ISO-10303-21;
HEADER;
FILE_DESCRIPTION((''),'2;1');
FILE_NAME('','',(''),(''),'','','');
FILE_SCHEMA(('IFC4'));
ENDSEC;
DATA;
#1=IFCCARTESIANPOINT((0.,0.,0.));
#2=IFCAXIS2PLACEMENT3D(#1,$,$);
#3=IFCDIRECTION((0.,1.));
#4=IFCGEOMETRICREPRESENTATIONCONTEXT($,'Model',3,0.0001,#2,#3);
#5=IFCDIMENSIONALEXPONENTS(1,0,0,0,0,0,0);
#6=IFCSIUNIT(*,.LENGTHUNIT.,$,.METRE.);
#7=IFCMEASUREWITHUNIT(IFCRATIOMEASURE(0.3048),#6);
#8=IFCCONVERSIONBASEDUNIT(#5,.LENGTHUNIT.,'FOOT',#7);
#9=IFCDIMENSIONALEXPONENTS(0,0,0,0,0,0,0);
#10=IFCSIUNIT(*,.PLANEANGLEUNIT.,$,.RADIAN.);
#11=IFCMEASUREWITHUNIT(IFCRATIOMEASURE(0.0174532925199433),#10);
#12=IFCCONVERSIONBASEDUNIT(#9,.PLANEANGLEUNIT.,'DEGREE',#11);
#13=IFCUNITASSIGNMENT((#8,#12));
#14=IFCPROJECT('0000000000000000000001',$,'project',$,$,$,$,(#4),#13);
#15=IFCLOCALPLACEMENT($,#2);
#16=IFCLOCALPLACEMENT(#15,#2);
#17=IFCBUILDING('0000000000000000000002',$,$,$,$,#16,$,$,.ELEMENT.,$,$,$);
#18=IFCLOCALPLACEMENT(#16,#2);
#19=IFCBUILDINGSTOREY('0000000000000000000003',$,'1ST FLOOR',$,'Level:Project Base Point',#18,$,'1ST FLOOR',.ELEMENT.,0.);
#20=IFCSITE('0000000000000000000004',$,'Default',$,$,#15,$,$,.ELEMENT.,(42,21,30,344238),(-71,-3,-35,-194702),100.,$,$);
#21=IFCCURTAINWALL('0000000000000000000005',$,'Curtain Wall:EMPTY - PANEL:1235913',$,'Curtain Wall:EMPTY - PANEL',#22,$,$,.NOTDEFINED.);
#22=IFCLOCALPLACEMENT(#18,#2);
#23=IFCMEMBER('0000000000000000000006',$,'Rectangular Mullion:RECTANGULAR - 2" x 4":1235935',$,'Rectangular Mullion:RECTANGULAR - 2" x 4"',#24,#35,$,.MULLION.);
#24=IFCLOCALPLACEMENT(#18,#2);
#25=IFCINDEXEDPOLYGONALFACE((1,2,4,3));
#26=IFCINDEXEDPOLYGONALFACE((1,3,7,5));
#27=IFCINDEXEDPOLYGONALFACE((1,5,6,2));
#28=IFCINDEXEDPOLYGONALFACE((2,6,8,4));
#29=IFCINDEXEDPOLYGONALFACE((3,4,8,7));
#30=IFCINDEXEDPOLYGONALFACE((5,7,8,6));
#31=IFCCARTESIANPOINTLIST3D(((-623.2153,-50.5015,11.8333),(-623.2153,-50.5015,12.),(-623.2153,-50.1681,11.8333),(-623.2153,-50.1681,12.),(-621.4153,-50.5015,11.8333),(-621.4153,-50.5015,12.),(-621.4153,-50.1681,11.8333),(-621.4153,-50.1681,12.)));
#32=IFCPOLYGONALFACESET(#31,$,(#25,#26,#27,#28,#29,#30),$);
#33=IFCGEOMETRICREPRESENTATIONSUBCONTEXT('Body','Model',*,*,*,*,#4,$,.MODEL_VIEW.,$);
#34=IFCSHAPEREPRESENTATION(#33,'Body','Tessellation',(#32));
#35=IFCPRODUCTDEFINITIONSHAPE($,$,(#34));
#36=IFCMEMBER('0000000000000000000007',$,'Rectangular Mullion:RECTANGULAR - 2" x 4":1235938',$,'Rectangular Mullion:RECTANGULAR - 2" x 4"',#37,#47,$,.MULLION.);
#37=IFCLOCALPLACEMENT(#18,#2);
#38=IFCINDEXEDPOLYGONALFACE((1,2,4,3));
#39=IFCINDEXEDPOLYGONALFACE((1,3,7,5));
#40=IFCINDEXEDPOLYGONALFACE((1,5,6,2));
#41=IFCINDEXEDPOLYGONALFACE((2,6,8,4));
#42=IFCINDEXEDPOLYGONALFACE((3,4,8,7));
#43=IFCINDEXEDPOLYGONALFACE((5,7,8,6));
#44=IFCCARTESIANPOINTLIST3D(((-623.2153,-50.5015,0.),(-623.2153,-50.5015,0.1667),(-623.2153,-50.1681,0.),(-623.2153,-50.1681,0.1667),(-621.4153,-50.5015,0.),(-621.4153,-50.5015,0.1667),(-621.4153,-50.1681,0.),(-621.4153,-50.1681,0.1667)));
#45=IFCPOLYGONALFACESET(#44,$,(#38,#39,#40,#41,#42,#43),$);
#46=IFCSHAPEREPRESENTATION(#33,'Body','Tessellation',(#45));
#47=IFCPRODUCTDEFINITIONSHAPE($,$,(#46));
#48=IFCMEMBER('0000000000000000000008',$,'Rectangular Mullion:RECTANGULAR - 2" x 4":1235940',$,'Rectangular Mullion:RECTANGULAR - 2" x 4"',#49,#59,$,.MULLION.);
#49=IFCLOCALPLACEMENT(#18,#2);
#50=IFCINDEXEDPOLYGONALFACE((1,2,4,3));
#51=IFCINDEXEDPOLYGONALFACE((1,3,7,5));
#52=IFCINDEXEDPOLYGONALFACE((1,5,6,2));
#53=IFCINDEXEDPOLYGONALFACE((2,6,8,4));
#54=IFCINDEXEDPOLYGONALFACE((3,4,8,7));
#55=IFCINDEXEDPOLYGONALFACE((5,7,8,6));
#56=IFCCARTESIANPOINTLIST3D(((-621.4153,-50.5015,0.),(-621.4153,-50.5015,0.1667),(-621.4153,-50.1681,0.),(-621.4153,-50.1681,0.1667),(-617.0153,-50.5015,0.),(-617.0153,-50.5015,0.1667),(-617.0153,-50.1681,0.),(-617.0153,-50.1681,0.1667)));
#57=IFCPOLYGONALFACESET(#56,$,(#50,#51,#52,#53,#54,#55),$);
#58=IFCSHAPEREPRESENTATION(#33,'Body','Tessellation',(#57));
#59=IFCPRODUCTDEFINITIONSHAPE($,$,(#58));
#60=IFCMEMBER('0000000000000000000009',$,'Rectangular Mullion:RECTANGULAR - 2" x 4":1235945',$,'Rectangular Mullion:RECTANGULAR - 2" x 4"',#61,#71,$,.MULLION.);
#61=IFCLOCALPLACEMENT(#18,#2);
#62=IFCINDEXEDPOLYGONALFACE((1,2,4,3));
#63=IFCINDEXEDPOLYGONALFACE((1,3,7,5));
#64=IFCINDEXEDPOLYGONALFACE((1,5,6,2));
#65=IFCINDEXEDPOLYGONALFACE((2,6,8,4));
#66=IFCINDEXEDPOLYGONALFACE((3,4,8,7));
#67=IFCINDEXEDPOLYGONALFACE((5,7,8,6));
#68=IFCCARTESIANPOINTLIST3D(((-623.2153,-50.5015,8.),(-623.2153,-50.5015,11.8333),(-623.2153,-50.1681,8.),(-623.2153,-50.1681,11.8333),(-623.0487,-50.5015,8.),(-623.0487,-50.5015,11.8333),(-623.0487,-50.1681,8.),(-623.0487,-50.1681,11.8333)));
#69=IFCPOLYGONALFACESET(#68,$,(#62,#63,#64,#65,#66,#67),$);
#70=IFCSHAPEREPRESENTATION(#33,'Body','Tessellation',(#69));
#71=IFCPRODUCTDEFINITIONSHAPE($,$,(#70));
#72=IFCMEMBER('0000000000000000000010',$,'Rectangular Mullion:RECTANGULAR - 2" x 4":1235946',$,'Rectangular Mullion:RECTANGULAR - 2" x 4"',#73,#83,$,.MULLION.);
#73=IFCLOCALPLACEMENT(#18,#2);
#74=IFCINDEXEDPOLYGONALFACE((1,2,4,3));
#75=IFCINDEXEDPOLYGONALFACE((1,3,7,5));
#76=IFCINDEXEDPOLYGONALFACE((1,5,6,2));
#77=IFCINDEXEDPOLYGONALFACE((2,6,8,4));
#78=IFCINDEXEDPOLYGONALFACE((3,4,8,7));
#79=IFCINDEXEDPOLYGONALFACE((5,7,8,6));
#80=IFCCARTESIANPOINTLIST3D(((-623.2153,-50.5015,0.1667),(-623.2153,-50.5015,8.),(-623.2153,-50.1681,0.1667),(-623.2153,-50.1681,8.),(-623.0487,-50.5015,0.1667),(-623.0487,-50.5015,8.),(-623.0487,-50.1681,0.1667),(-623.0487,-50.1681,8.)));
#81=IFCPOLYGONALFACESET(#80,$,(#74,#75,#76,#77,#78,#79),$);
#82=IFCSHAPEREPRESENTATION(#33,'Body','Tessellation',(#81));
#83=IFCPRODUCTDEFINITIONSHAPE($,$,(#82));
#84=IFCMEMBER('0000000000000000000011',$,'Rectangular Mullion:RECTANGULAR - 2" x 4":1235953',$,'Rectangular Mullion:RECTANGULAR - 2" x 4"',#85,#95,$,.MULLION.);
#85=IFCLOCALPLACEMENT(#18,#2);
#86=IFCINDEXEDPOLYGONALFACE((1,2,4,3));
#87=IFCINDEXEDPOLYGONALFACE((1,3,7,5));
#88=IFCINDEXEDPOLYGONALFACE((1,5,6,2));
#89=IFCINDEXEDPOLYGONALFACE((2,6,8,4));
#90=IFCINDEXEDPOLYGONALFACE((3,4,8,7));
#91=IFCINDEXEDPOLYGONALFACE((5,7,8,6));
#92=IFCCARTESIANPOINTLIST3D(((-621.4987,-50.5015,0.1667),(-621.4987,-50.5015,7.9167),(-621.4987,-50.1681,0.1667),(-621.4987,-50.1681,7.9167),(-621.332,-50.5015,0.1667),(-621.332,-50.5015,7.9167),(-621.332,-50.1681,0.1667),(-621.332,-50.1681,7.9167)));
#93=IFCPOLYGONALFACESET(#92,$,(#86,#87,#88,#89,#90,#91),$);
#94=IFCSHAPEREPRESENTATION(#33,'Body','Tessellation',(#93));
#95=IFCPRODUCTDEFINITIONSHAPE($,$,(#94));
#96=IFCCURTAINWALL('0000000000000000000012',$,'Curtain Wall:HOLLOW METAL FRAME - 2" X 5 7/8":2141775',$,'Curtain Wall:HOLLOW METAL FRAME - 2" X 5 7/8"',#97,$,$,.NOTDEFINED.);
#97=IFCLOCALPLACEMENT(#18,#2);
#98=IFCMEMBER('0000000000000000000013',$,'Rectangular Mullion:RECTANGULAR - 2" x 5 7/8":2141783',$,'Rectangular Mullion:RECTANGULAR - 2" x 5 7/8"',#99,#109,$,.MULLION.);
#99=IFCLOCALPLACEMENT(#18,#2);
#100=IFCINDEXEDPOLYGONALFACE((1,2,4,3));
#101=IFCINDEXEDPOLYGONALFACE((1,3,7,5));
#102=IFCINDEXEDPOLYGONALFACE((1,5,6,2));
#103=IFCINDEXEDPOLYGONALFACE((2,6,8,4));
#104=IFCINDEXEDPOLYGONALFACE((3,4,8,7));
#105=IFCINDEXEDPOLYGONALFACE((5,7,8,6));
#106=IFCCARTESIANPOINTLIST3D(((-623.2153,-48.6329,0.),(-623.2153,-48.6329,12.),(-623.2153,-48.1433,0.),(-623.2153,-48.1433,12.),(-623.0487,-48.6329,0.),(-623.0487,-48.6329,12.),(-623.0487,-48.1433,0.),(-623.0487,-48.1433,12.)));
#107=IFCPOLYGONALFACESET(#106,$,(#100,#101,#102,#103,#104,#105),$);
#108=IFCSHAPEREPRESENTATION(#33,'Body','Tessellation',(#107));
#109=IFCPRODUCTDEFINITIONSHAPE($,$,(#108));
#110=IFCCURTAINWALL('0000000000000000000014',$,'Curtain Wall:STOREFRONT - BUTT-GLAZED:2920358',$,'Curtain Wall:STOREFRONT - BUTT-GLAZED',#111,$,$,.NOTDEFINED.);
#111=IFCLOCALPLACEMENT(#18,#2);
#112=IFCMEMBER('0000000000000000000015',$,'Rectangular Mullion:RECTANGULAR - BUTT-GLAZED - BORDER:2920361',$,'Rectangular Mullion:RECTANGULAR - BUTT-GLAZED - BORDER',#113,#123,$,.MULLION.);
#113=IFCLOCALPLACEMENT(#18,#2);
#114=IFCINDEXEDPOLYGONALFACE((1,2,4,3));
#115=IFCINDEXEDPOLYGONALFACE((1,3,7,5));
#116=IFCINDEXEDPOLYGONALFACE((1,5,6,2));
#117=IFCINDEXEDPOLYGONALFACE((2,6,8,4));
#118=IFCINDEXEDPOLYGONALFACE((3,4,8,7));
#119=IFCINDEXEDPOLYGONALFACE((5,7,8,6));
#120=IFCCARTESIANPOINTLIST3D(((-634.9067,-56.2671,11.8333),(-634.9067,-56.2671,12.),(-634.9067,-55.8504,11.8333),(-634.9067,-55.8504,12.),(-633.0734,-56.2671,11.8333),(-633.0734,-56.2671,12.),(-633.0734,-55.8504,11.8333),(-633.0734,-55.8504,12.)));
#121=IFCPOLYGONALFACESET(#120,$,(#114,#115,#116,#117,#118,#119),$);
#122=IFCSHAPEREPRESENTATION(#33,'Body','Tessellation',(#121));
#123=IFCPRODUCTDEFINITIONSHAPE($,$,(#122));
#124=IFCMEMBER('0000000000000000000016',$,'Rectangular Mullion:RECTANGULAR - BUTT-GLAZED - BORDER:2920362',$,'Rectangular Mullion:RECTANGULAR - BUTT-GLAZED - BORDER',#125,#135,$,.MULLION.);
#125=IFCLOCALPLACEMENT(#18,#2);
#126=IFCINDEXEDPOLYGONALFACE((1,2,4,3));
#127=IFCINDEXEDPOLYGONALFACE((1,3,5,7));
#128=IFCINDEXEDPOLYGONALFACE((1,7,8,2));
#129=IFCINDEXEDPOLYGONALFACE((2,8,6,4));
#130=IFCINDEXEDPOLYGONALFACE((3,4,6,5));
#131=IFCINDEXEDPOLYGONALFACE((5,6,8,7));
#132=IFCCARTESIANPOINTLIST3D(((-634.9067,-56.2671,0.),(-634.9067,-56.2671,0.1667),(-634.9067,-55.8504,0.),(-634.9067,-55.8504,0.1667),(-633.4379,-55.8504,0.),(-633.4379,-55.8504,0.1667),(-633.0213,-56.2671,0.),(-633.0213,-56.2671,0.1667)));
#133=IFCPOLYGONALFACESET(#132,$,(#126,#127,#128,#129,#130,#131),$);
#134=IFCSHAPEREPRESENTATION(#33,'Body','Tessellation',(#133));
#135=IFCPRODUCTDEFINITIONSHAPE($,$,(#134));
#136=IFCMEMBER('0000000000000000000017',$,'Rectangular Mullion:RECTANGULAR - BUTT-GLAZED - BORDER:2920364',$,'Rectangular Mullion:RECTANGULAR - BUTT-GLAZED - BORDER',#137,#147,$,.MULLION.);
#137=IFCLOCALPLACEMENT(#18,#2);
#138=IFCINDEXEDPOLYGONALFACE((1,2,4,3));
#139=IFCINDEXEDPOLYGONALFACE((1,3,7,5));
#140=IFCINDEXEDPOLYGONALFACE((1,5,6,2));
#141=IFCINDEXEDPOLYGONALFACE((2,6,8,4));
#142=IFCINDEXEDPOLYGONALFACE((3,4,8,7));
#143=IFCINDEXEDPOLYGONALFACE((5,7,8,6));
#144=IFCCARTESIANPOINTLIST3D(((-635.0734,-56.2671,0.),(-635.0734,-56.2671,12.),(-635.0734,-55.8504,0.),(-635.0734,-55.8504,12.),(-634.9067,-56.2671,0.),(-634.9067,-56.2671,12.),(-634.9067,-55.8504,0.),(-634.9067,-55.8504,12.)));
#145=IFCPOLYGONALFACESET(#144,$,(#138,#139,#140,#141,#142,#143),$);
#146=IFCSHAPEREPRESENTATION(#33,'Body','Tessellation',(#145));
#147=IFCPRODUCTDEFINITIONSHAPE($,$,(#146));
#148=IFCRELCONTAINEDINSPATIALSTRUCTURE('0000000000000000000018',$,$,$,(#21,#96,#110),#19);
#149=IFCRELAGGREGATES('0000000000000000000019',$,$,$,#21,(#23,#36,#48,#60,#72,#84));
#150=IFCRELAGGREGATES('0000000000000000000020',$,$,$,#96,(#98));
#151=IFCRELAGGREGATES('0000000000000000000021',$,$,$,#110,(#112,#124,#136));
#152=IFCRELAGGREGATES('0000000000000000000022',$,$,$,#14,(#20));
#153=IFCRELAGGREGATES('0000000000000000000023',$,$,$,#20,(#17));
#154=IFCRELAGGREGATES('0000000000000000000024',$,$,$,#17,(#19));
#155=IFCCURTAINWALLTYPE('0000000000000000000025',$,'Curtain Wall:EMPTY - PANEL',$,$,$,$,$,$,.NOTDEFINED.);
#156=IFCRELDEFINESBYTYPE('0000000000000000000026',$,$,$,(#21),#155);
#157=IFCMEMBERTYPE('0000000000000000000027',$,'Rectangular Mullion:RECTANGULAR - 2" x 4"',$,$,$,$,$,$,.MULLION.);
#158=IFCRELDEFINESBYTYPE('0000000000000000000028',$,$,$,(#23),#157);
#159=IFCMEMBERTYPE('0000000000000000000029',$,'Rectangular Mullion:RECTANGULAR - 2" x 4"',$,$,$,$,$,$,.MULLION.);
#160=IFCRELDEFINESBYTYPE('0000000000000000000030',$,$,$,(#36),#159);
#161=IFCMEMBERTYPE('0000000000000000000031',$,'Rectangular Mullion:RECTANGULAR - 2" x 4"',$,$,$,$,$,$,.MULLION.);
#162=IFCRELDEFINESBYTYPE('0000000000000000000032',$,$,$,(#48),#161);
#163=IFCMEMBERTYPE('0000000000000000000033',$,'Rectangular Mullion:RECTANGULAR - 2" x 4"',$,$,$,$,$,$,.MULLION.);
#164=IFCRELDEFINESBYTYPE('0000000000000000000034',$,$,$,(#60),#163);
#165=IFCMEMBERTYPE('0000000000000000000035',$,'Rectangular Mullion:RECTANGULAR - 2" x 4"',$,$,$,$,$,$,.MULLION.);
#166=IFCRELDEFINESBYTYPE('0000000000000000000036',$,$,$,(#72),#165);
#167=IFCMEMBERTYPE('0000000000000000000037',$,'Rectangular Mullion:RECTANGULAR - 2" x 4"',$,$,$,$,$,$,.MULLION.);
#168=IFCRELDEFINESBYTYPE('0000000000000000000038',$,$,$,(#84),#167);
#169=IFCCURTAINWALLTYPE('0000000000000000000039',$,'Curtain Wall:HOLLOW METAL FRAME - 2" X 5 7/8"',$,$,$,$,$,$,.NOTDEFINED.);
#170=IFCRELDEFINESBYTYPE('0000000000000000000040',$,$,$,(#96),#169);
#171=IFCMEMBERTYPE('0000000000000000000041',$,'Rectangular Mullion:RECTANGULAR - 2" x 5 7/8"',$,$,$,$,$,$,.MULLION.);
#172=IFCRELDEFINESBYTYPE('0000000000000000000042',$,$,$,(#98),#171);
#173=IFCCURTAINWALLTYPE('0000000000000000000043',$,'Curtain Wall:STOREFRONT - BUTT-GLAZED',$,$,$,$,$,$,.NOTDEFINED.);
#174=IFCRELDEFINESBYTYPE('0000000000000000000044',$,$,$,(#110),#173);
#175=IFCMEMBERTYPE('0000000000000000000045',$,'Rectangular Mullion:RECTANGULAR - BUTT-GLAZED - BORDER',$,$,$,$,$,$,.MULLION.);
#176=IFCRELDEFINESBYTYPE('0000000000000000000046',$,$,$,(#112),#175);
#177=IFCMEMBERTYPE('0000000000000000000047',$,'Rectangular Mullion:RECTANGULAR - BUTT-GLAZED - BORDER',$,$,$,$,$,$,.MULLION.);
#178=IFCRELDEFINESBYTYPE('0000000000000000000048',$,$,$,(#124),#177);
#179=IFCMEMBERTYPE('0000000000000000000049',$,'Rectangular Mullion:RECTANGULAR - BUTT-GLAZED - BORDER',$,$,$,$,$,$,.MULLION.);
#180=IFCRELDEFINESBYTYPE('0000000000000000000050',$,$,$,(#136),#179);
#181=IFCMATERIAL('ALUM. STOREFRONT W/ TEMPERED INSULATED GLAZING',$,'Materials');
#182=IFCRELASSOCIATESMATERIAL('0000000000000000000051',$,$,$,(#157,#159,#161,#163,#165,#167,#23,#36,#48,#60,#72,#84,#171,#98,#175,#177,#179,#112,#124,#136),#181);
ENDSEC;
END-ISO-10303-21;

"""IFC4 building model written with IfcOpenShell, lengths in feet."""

from ifc_helpers import new_model, entity, si_unit, converted_unit, direction, frame, frame_2d, origin, origin_2d_with_axis, place, context, subcontext, project, spatial, rectangle, extrude, clip, halfspace, source, transform, mapped, material, material_profile, profile_set, profile_usage, type_object, type_shapes, element, aggregate, save


model = new_model("IFC4")

# Units and contexts
model_context = context("Model", 3, precision=0.0001, world=origin(), true_north=direction((0.0, 1.0)))
body_context = subcontext(model_context, "Body", "Model", "MODEL_VIEW")
ifc_project = project(units=[converted_unit("LENGTHUNIT", "FOOT", entity("IfcRatioMeasure", 0.3048), si_unit("LENGTHUNIT", "METRE"), dimensions=[1, 0, 0, 0, 0, 0, 0]), converted_unit("PLANEANGLEUNIT", "DEGREE", entity("IfcRatioMeasure", 0.0174532925199433), si_unit("PLANEANGLEUNIT", "RADIAN"), dimensions=[0, 0, 0, 0, 0, 0, 0])], contexts=[model_context])

# Site, building, storey
site_placement = place(None, origin())
site = spatial("IfcSite", under=ifc_project, at=site_placement, Name="Default", CompositionType="ELEMENT", RefLatitude=(42, 21, 30, 344238), RefLongitude=(-71, -3, -35, -194702), RefElevation=100.0)
building_placement = place(site_placement, origin())
building = spatial("IfcBuilding", under=site, at=building_placement, CompositionType="ELEMENT")
storey_placement = place(building_placement, origin())
storey = spatial("IfcBuildingStorey", under=building, at=storey_placement, Name="1ST FLOOR", ObjectType="Level:Project Base Point", LongName="1ST FLOOR", CompositionType="ELEMENT", Elevation=0.0)

# Curtain wall, members
curtain_wall_type_1 = type_object("IfcCurtainWallType", Name="Curtain Wall:EMPTY - PANEL", PredefinedType="NOTDEFINED")
curtain_wall_1_placement = place(storey_placement, origin())
curtain_wall_1 = element("IfcCurtainWall", 1, at=curtain_wall_1_placement, inside=storey, type_object=curtain_wall_type_1, Name="Curtain Wall:EMPTY - PANEL:1235913", ObjectType="Curtain Wall:EMPTY - PANEL", PredefinedType="NOTDEFINED")
ifc_material_1 = material(Name="ALUM. STOREFRONT W/ TEMPERED INSULATED GLAZING", Category="Materials")
ifc_material_profile_1 = material_profile(ifc_material_1, rectangle(XDim=0.3333, YDim=0.1667, at=origin_2d_with_axis()), Name="RECTANGULAR - 2\" x 4\"")
ifc_profile_set_1 = profile_set([ifc_material_profile_1], Name="RECTANGULAR - 2\" x 4\"")
ifc_profile_usage_1 = profile_usage(ifc_profile_set_1)
member_type_1 = type_object("IfcMemberType", Name="Rectangular Mullion:RECTANGULAR - 2\" x 4\"", PredefinedType="MULLION", material=ifc_profile_set_1)
shared_shape_1 = source(origin(), body_context, "Body", "SweptSolid", [
    extrude(rectangle(XDim=0.3333, YDim=0.1667, at=origin_2d_with_axis()), frame((-0.0833, 0.0, -1.8), z_axis=(0.0, 0.0, 1.0), x_axis=(0.0, -1.0, 0.0)), (0.0, 0.0, 1.0), 1.8),
])
type_shapes(member_type_1, [shared_shape_1])
member_1_placement = place(storey_placement, frame((-621.4153, -50.3348, 12.0), z_axis=(1.0, 0.0, 0.0), x_axis=(0.0, 0.0, 1.0)))
member_1 = element("IfcMember", 2, at=member_1_placement, type_object=member_type_1, material=ifc_profile_usage_1, Name="Rectangular Mullion:RECTANGULAR - 2\" x 4\":1235935", ObjectType="Rectangular Mullion:RECTANGULAR - 2\" x 4\"", PredefinedType="MULLION", context=body_context, shape_type="MappedRepresentation", body=[
    mapped(shared_shape_1, transform((0.0, 0.0, 0.0), scale=1.0)),
])
ifc_profile_usage_2 = profile_usage(ifc_profile_set_1)
member_type_2 = type_object("IfcMemberType", Name="Rectangular Mullion:RECTANGULAR - 2\" x 4\"", PredefinedType="MULLION", material=ifc_profile_set_1)
shared_shape_2 = source(origin(), body_context, "Body", "SweptSolid", [
    extrude(rectangle(XDim=0.3333, YDim=0.1667, at=origin_2d_with_axis()), frame((-0.0833, 0.0, -1.8), z_axis=(0.0, 0.0, 1.0), x_axis=(0.0, -1.0, 0.0)), (0.0, 0.0, 1.0), 1.8),
])
type_shapes(member_type_2, [shared_shape_2])
member_2_placement = place(storey_placement, frame((-623.2153, -50.3348, 0.0), z_axis=(-1.0, 0.0, 0.0), x_axis=(0.0, 0.0, -1.0)))
member_2 = element("IfcMember", 3, at=member_2_placement, type_object=member_type_2, material=ifc_profile_usage_2, Name="Rectangular Mullion:RECTANGULAR - 2\" x 4\":1235938", ObjectType="Rectangular Mullion:RECTANGULAR - 2\" x 4\"", PredefinedType="MULLION", context=body_context, shape_type="MappedRepresentation", body=[
    mapped(shared_shape_2, transform((0.0, 0.0, 0.0), scale=1.0)),
])
ifc_profile_usage_3 = profile_usage(ifc_profile_set_1)
member_type_3 = type_object("IfcMemberType", Name="Rectangular Mullion:RECTANGULAR - 2\" x 4\"", PredefinedType="MULLION", material=ifc_profile_set_1)
shared_shape_3 = source(origin(), body_context, "Body", "SweptSolid", [
    extrude(rectangle(XDim=0.3333, YDim=0.1667, at=origin_2d_with_axis()), frame((-0.0833, 0.0, -4.4), z_axis=(0.0, 0.0, 1.0), x_axis=(0.0, -1.0, 0.0)), (0.0, 0.0, 1.0), 4.4),
])
type_shapes(member_type_3, [shared_shape_3])
member_3_placement = place(storey_placement, frame((-621.4153, -50.3348, 0.0), z_axis=(-1.0, 0.0, 0.0), x_axis=(0.0, 0.0, -1.0)))
member_3 = element("IfcMember", 4, at=member_3_placement, type_object=member_type_3, material=ifc_profile_usage_3, Name="Rectangular Mullion:RECTANGULAR - 2\" x 4\":1235940", ObjectType="Rectangular Mullion:RECTANGULAR - 2\" x 4\"", PredefinedType="MULLION", context=body_context, shape_type="MappedRepresentation", body=[
    mapped(shared_shape_3, transform((0.0, 0.0, 0.0), scale=1.0)),
])
ifc_profile_usage_4 = profile_usage(ifc_profile_set_1)
member_type_4 = type_object("IfcMemberType", Name="Rectangular Mullion:RECTANGULAR - 2\" x 4\"", PredefinedType="MULLION", material=ifc_profile_set_1)
shared_shape_4 = source(origin(), body_context, "Body", "SweptSolid", [
    extrude(rectangle(XDim=0.3333, YDim=0.1667, at=origin_2d_with_axis()), frame((-0.0833, 0.0, -3.8333), z_axis=(0.0, 0.0, 1.0), x_axis=(0.0, -1.0, 0.0)), (0.0, 0.0, 1.0), 3.8333),
])
type_shapes(member_type_4, [shared_shape_4])
member_4_placement = place(storey_placement, frame((-623.2153, -50.3348, 11.8333), z_axis=(0.0, 0.0, 1.0), x_axis=(-1.0, 0.0, 0.0)))
member_4 = element("IfcMember", 5, at=member_4_placement, type_object=member_type_4, material=ifc_profile_usage_4, Name="Rectangular Mullion:RECTANGULAR - 2\" x 4\":1235945", ObjectType="Rectangular Mullion:RECTANGULAR - 2\" x 4\"", PredefinedType="MULLION", context=body_context, shape_type="MappedRepresentation", body=[
    mapped(shared_shape_4, transform((0.0, 0.0, 0.0), scale=1.0)),
])
ifc_profile_usage_5 = profile_usage(ifc_profile_set_1)
member_type_5 = type_object("IfcMemberType", Name="Rectangular Mullion:RECTANGULAR - 2\" x 4\"", PredefinedType="MULLION", material=ifc_profile_set_1)
shared_shape_5 = source(origin(), body_context, "Body", "SweptSolid", [
    extrude(rectangle(XDim=0.3333, YDim=0.1667, at=origin_2d_with_axis()), frame((-0.0833, 0.0, -7.8333), z_axis=(0.0, 0.0, 1.0), x_axis=(0.0, -1.0, 0.0)), (0.0, 0.0, 1.0), 7.8333),
])
type_shapes(member_type_5, [shared_shape_5])
member_5_placement = place(storey_placement, frame((-623.2153, -50.3348, 8.0), z_axis=(0.0, 0.0, 1.0), x_axis=(-1.0, 0.0, 0.0)))
member_5 = element("IfcMember", 6, at=member_5_placement, type_object=member_type_5, material=ifc_profile_usage_5, Name="Rectangular Mullion:RECTANGULAR - 2\" x 4\":1235946", ObjectType="Rectangular Mullion:RECTANGULAR - 2\" x 4\"", PredefinedType="MULLION", context=body_context, shape_type="MappedRepresentation", body=[
    mapped(shared_shape_5, transform((0.0, 0.0, 0.0), scale=1.0)),
])
ifc_profile_usage_6 = profile_usage(ifc_profile_set_1)
member_type_6 = type_object("IfcMemberType", Name="Rectangular Mullion:RECTANGULAR - 2\" x 4\"", PredefinedType="MULLION", material=ifc_profile_set_1)
shared_shape_6 = source(origin(), body_context, "Body", "SweptSolid", [
    extrude(rectangle(XDim=0.3333, YDim=0.1667, at=origin_2d_with_axis()), frame((0.0, 0.0, -7.75), z_axis=(0.0, 0.0, 1.0), x_axis=(0.0, -1.0, 0.0)), (0.0, 0.0, 1.0), 7.75),
])
type_shapes(member_type_6, [shared_shape_6])
member_6_placement = place(storey_placement, frame((-621.4153, -50.3348, 0.1667), z_axis=(0.0, 0.0, -1.0), x_axis=(1.0, 0.0, 0.0)))
member_6 = element("IfcMember", 7, at=member_6_placement, type_object=member_type_6, material=ifc_profile_usage_6, Name="Rectangular Mullion:RECTANGULAR - 2\" x 4\":1235953", ObjectType="Rectangular Mullion:RECTANGULAR - 2\" x 4\"", PredefinedType="MULLION", context=body_context, shape_type="MappedRepresentation", body=[
    mapped(shared_shape_6, transform((0.0, 0.0, 0.0), scale=1.0)),
])
aggregate(curtain_wall_1, [member_1, member_2, member_3, member_4, member_5, member_6])

# Curtain wall, member
curtain_wall_type_2 = type_object("IfcCurtainWallType", Name="Curtain Wall:HOLLOW METAL FRAME - 2\" X 5 7/8\"", PredefinedType="NOTDEFINED")
curtain_wall_2_placement = place(storey_placement, origin())
curtain_wall_2 = element("IfcCurtainWall", 8, at=curtain_wall_2_placement, inside=storey, type_object=curtain_wall_type_2, Name="Curtain Wall:HOLLOW METAL FRAME - 2\" X 5 7/8\":2141775", ObjectType="Curtain Wall:HOLLOW METAL FRAME - 2\" X 5 7/8\"", PredefinedType="NOTDEFINED")
ifc_material_profile_2 = material_profile(ifc_material_1, rectangle(XDim=0.4896, YDim=0.1667, at=origin_2d_with_axis()), Name="RECTANGULAR - 2\" x 5 7/8\"")
ifc_profile_set_2 = profile_set([ifc_material_profile_2], Name="RECTANGULAR - 2\" x 5 7/8\"")
ifc_profile_usage_7 = profile_usage(ifc_profile_set_2)
member_type_7 = type_object("IfcMemberType", Name="Rectangular Mullion:RECTANGULAR - 2\" x 5 7/8\"", PredefinedType="MULLION", material=ifc_profile_set_2)
shared_shape_7 = source(origin(), body_context, "Body", "SweptSolid", [
    extrude(rectangle(XDim=0.4896, YDim=0.1667, at=origin_2d_with_axis()), frame((-0.0833, 0.0, -12.0), z_axis=(0.0, 0.0, 1.0), x_axis=(0.0, -1.0, 0.0)), (0.0, 0.0, 1.0), 12.0),
])
type_shapes(member_type_7, [shared_shape_7])
member_7_placement = place(storey_placement, frame((-623.2153, -48.3881, 12.0), z_axis=(0.0, 0.0, 1.0), x_axis=(-1.0, 0.0, 0.0)))
member_7 = element("IfcMember", 9, at=member_7_placement, type_object=member_type_7, material=ifc_profile_usage_7, Name="Rectangular Mullion:RECTANGULAR - 2\" x 5 7/8\":2141783", ObjectType="Rectangular Mullion:RECTANGULAR - 2\" x 5 7/8\"", PredefinedType="MULLION", context=body_context, shape_type="MappedRepresentation", body=[
    mapped(shared_shape_7, transform((0.0, 0.0, 0.0), scale=1.0)),
])

# Curtain wall, members
curtain_wall_type_3 = type_object("IfcCurtainWallType", Name="Curtain Wall:STOREFRONT - BUTT-GLAZED", PredefinedType="NOTDEFINED")
curtain_wall_3_placement = place(storey_placement, origin())
curtain_wall_3 = element("IfcCurtainWall", 10, at=curtain_wall_3_placement, inside=storey, type_object=curtain_wall_type_3, Name="Curtain Wall:STOREFRONT - BUTT-GLAZED:2920358", ObjectType="Curtain Wall:STOREFRONT - BUTT-GLAZED", PredefinedType="NOTDEFINED")
ifc_material_profile_3 = material_profile(ifc_material_1, rectangle(XDim=0.4167, YDim=0.1667, at=frame_2d((0.0, 0.0), x_axis=(1.0, 0.0))), Name="RECTANGULAR - BUTT-GLAZED - BORDER")
ifc_profile_set_3 = profile_set([ifc_material_profile_3], Name="RECTANGULAR - BUTT-GLAZED - BORDER")
ifc_profile_usage_8 = profile_usage(ifc_profile_set_3)
member_type_8 = type_object("IfcMemberType", Name="Rectangular Mullion:RECTANGULAR - BUTT-GLAZED - BORDER", PredefinedType="MULLION", material=ifc_profile_set_3)
shared_shape_8 = source(origin(), body_context, "Body", "SweptSolid", [
    extrude(rectangle(XDim=0.4167, YDim=0.1667, at=frame_2d((0.0, 0.0), x_axis=(1.0, 0.0))), frame((-0.0833, -0.1562, -1.8333), z_axis=(0.0, 0.0, 1.0), x_axis=(0.0, -1.0, 0.0)), (0.0, 0.0, 1.0), 1.8333),
])
type_shapes(member_type_8, [shared_shape_8])
member_8_placement = place(storey_placement, frame((-633.0734, -56.215, 12.0), z_axis=(1.0, 0.0, 0.0), x_axis=(0.0, 0.0, 1.0)))
member_8 = element("IfcMember", 11, at=member_8_placement, type_object=member_type_8, material=ifc_profile_usage_8, Name="Rectangular Mullion:RECTANGULAR - BUTT-GLAZED - BORDER:2920361", ObjectType="Rectangular Mullion:RECTANGULAR - BUTT-GLAZED - BORDER", PredefinedType="MULLION", context=body_context, shape_type="MappedRepresentation", body=[
    mapped(shared_shape_8, transform((0.0, 0.0, 0.0), scale=1.0)),
])
ifc_profile_usage_9 = profile_usage(ifc_profile_set_3)
member_type_9 = type_object("IfcMemberType", Name="Rectangular Mullion:RECTANGULAR - BUTT-GLAZED - BORDER", PredefinedType="MULLION", material=ifc_profile_set_3)
shared_shape_9 = source(origin(), body_context, "Body", "Clipping", [
    clip(extrude(rectangle(XDim=0.4167, YDim=0.1667, at=frame_2d((0.0, 0.0), x_axis=(1.0, 0.0))), frame((-0.0833, -0.1562, -1.8854), z_axis=(0.0, 0.0, 1.0), x_axis=(0.0, -1.0, 0.0)), (0.0, 0.0, 1.0), 1.8854), halfspace(frame((1.0, 0.0, -1.8333), z_axis=(0.0, -0.707107, -0.707107), x_axis=(0.0, -0.707107, 0.707107)), False)),
])
type_shapes(member_type_9, [shared_shape_9])
member_9_placement = place(storey_placement, frame((-634.9067, -56.215, 0.0), z_axis=(-1.0, 0.0, 0.0), x_axis=(0.0, 0.0, -1.0)))
member_9 = element("IfcMember", 12, at=member_9_placement, type_object=member_type_9, material=ifc_profile_usage_9, Name="Rectangular Mullion:RECTANGULAR - BUTT-GLAZED - BORDER:2920362", ObjectType="Rectangular Mullion:RECTANGULAR - BUTT-GLAZED - BORDER", PredefinedType="MULLION", context=body_context, shape_type="MappedRepresentation", body=[
    mapped(shared_shape_9, transform((0.0, 0.0, 0.0), scale=1.0)),
])
ifc_profile_usage_10 = profile_usage(ifc_profile_set_3)
member_type_10 = type_object("IfcMemberType", Name="Rectangular Mullion:RECTANGULAR - BUTT-GLAZED - BORDER", PredefinedType="MULLION", material=ifc_profile_set_3)
shared_shape_10 = source(origin(), body_context, "Body", "SweptSolid", [
    extrude(rectangle(XDim=0.4167, YDim=0.1667, at=origin_2d_with_axis()), frame((-0.0833, -0.1562, -12.0), z_axis=(0.0, 0.0, 1.0), x_axis=(0.0, -1.0, 0.0)), (0.0, 0.0, 1.0), 12.0),
])
type_shapes(member_type_10, [shared_shape_10])
member_10_placement = place(storey_placement, frame((-635.0734, -56.215, 12.0), z_axis=(0.0, 0.0, 1.0), x_axis=(-1.0, 0.0, 0.0)))
member_10 = element("IfcMember", 13, at=member_10_placement, type_object=member_type_10, material=ifc_profile_usage_10, Name="Rectangular Mullion:RECTANGULAR - BUTT-GLAZED - BORDER:2920364", ObjectType="Rectangular Mullion:RECTANGULAR - BUTT-GLAZED - BORDER", PredefinedType="MULLION", context=body_context, shape_type="MappedRepresentation", body=[
    mapped(shared_shape_10, transform((0.0, 0.0, 0.0), scale=1.0)),
])

aggregate(curtain_wall_2, [member_7])
aggregate(curtain_wall_3, [member_8, member_9, member_10])

save(model, "model.ifc")
